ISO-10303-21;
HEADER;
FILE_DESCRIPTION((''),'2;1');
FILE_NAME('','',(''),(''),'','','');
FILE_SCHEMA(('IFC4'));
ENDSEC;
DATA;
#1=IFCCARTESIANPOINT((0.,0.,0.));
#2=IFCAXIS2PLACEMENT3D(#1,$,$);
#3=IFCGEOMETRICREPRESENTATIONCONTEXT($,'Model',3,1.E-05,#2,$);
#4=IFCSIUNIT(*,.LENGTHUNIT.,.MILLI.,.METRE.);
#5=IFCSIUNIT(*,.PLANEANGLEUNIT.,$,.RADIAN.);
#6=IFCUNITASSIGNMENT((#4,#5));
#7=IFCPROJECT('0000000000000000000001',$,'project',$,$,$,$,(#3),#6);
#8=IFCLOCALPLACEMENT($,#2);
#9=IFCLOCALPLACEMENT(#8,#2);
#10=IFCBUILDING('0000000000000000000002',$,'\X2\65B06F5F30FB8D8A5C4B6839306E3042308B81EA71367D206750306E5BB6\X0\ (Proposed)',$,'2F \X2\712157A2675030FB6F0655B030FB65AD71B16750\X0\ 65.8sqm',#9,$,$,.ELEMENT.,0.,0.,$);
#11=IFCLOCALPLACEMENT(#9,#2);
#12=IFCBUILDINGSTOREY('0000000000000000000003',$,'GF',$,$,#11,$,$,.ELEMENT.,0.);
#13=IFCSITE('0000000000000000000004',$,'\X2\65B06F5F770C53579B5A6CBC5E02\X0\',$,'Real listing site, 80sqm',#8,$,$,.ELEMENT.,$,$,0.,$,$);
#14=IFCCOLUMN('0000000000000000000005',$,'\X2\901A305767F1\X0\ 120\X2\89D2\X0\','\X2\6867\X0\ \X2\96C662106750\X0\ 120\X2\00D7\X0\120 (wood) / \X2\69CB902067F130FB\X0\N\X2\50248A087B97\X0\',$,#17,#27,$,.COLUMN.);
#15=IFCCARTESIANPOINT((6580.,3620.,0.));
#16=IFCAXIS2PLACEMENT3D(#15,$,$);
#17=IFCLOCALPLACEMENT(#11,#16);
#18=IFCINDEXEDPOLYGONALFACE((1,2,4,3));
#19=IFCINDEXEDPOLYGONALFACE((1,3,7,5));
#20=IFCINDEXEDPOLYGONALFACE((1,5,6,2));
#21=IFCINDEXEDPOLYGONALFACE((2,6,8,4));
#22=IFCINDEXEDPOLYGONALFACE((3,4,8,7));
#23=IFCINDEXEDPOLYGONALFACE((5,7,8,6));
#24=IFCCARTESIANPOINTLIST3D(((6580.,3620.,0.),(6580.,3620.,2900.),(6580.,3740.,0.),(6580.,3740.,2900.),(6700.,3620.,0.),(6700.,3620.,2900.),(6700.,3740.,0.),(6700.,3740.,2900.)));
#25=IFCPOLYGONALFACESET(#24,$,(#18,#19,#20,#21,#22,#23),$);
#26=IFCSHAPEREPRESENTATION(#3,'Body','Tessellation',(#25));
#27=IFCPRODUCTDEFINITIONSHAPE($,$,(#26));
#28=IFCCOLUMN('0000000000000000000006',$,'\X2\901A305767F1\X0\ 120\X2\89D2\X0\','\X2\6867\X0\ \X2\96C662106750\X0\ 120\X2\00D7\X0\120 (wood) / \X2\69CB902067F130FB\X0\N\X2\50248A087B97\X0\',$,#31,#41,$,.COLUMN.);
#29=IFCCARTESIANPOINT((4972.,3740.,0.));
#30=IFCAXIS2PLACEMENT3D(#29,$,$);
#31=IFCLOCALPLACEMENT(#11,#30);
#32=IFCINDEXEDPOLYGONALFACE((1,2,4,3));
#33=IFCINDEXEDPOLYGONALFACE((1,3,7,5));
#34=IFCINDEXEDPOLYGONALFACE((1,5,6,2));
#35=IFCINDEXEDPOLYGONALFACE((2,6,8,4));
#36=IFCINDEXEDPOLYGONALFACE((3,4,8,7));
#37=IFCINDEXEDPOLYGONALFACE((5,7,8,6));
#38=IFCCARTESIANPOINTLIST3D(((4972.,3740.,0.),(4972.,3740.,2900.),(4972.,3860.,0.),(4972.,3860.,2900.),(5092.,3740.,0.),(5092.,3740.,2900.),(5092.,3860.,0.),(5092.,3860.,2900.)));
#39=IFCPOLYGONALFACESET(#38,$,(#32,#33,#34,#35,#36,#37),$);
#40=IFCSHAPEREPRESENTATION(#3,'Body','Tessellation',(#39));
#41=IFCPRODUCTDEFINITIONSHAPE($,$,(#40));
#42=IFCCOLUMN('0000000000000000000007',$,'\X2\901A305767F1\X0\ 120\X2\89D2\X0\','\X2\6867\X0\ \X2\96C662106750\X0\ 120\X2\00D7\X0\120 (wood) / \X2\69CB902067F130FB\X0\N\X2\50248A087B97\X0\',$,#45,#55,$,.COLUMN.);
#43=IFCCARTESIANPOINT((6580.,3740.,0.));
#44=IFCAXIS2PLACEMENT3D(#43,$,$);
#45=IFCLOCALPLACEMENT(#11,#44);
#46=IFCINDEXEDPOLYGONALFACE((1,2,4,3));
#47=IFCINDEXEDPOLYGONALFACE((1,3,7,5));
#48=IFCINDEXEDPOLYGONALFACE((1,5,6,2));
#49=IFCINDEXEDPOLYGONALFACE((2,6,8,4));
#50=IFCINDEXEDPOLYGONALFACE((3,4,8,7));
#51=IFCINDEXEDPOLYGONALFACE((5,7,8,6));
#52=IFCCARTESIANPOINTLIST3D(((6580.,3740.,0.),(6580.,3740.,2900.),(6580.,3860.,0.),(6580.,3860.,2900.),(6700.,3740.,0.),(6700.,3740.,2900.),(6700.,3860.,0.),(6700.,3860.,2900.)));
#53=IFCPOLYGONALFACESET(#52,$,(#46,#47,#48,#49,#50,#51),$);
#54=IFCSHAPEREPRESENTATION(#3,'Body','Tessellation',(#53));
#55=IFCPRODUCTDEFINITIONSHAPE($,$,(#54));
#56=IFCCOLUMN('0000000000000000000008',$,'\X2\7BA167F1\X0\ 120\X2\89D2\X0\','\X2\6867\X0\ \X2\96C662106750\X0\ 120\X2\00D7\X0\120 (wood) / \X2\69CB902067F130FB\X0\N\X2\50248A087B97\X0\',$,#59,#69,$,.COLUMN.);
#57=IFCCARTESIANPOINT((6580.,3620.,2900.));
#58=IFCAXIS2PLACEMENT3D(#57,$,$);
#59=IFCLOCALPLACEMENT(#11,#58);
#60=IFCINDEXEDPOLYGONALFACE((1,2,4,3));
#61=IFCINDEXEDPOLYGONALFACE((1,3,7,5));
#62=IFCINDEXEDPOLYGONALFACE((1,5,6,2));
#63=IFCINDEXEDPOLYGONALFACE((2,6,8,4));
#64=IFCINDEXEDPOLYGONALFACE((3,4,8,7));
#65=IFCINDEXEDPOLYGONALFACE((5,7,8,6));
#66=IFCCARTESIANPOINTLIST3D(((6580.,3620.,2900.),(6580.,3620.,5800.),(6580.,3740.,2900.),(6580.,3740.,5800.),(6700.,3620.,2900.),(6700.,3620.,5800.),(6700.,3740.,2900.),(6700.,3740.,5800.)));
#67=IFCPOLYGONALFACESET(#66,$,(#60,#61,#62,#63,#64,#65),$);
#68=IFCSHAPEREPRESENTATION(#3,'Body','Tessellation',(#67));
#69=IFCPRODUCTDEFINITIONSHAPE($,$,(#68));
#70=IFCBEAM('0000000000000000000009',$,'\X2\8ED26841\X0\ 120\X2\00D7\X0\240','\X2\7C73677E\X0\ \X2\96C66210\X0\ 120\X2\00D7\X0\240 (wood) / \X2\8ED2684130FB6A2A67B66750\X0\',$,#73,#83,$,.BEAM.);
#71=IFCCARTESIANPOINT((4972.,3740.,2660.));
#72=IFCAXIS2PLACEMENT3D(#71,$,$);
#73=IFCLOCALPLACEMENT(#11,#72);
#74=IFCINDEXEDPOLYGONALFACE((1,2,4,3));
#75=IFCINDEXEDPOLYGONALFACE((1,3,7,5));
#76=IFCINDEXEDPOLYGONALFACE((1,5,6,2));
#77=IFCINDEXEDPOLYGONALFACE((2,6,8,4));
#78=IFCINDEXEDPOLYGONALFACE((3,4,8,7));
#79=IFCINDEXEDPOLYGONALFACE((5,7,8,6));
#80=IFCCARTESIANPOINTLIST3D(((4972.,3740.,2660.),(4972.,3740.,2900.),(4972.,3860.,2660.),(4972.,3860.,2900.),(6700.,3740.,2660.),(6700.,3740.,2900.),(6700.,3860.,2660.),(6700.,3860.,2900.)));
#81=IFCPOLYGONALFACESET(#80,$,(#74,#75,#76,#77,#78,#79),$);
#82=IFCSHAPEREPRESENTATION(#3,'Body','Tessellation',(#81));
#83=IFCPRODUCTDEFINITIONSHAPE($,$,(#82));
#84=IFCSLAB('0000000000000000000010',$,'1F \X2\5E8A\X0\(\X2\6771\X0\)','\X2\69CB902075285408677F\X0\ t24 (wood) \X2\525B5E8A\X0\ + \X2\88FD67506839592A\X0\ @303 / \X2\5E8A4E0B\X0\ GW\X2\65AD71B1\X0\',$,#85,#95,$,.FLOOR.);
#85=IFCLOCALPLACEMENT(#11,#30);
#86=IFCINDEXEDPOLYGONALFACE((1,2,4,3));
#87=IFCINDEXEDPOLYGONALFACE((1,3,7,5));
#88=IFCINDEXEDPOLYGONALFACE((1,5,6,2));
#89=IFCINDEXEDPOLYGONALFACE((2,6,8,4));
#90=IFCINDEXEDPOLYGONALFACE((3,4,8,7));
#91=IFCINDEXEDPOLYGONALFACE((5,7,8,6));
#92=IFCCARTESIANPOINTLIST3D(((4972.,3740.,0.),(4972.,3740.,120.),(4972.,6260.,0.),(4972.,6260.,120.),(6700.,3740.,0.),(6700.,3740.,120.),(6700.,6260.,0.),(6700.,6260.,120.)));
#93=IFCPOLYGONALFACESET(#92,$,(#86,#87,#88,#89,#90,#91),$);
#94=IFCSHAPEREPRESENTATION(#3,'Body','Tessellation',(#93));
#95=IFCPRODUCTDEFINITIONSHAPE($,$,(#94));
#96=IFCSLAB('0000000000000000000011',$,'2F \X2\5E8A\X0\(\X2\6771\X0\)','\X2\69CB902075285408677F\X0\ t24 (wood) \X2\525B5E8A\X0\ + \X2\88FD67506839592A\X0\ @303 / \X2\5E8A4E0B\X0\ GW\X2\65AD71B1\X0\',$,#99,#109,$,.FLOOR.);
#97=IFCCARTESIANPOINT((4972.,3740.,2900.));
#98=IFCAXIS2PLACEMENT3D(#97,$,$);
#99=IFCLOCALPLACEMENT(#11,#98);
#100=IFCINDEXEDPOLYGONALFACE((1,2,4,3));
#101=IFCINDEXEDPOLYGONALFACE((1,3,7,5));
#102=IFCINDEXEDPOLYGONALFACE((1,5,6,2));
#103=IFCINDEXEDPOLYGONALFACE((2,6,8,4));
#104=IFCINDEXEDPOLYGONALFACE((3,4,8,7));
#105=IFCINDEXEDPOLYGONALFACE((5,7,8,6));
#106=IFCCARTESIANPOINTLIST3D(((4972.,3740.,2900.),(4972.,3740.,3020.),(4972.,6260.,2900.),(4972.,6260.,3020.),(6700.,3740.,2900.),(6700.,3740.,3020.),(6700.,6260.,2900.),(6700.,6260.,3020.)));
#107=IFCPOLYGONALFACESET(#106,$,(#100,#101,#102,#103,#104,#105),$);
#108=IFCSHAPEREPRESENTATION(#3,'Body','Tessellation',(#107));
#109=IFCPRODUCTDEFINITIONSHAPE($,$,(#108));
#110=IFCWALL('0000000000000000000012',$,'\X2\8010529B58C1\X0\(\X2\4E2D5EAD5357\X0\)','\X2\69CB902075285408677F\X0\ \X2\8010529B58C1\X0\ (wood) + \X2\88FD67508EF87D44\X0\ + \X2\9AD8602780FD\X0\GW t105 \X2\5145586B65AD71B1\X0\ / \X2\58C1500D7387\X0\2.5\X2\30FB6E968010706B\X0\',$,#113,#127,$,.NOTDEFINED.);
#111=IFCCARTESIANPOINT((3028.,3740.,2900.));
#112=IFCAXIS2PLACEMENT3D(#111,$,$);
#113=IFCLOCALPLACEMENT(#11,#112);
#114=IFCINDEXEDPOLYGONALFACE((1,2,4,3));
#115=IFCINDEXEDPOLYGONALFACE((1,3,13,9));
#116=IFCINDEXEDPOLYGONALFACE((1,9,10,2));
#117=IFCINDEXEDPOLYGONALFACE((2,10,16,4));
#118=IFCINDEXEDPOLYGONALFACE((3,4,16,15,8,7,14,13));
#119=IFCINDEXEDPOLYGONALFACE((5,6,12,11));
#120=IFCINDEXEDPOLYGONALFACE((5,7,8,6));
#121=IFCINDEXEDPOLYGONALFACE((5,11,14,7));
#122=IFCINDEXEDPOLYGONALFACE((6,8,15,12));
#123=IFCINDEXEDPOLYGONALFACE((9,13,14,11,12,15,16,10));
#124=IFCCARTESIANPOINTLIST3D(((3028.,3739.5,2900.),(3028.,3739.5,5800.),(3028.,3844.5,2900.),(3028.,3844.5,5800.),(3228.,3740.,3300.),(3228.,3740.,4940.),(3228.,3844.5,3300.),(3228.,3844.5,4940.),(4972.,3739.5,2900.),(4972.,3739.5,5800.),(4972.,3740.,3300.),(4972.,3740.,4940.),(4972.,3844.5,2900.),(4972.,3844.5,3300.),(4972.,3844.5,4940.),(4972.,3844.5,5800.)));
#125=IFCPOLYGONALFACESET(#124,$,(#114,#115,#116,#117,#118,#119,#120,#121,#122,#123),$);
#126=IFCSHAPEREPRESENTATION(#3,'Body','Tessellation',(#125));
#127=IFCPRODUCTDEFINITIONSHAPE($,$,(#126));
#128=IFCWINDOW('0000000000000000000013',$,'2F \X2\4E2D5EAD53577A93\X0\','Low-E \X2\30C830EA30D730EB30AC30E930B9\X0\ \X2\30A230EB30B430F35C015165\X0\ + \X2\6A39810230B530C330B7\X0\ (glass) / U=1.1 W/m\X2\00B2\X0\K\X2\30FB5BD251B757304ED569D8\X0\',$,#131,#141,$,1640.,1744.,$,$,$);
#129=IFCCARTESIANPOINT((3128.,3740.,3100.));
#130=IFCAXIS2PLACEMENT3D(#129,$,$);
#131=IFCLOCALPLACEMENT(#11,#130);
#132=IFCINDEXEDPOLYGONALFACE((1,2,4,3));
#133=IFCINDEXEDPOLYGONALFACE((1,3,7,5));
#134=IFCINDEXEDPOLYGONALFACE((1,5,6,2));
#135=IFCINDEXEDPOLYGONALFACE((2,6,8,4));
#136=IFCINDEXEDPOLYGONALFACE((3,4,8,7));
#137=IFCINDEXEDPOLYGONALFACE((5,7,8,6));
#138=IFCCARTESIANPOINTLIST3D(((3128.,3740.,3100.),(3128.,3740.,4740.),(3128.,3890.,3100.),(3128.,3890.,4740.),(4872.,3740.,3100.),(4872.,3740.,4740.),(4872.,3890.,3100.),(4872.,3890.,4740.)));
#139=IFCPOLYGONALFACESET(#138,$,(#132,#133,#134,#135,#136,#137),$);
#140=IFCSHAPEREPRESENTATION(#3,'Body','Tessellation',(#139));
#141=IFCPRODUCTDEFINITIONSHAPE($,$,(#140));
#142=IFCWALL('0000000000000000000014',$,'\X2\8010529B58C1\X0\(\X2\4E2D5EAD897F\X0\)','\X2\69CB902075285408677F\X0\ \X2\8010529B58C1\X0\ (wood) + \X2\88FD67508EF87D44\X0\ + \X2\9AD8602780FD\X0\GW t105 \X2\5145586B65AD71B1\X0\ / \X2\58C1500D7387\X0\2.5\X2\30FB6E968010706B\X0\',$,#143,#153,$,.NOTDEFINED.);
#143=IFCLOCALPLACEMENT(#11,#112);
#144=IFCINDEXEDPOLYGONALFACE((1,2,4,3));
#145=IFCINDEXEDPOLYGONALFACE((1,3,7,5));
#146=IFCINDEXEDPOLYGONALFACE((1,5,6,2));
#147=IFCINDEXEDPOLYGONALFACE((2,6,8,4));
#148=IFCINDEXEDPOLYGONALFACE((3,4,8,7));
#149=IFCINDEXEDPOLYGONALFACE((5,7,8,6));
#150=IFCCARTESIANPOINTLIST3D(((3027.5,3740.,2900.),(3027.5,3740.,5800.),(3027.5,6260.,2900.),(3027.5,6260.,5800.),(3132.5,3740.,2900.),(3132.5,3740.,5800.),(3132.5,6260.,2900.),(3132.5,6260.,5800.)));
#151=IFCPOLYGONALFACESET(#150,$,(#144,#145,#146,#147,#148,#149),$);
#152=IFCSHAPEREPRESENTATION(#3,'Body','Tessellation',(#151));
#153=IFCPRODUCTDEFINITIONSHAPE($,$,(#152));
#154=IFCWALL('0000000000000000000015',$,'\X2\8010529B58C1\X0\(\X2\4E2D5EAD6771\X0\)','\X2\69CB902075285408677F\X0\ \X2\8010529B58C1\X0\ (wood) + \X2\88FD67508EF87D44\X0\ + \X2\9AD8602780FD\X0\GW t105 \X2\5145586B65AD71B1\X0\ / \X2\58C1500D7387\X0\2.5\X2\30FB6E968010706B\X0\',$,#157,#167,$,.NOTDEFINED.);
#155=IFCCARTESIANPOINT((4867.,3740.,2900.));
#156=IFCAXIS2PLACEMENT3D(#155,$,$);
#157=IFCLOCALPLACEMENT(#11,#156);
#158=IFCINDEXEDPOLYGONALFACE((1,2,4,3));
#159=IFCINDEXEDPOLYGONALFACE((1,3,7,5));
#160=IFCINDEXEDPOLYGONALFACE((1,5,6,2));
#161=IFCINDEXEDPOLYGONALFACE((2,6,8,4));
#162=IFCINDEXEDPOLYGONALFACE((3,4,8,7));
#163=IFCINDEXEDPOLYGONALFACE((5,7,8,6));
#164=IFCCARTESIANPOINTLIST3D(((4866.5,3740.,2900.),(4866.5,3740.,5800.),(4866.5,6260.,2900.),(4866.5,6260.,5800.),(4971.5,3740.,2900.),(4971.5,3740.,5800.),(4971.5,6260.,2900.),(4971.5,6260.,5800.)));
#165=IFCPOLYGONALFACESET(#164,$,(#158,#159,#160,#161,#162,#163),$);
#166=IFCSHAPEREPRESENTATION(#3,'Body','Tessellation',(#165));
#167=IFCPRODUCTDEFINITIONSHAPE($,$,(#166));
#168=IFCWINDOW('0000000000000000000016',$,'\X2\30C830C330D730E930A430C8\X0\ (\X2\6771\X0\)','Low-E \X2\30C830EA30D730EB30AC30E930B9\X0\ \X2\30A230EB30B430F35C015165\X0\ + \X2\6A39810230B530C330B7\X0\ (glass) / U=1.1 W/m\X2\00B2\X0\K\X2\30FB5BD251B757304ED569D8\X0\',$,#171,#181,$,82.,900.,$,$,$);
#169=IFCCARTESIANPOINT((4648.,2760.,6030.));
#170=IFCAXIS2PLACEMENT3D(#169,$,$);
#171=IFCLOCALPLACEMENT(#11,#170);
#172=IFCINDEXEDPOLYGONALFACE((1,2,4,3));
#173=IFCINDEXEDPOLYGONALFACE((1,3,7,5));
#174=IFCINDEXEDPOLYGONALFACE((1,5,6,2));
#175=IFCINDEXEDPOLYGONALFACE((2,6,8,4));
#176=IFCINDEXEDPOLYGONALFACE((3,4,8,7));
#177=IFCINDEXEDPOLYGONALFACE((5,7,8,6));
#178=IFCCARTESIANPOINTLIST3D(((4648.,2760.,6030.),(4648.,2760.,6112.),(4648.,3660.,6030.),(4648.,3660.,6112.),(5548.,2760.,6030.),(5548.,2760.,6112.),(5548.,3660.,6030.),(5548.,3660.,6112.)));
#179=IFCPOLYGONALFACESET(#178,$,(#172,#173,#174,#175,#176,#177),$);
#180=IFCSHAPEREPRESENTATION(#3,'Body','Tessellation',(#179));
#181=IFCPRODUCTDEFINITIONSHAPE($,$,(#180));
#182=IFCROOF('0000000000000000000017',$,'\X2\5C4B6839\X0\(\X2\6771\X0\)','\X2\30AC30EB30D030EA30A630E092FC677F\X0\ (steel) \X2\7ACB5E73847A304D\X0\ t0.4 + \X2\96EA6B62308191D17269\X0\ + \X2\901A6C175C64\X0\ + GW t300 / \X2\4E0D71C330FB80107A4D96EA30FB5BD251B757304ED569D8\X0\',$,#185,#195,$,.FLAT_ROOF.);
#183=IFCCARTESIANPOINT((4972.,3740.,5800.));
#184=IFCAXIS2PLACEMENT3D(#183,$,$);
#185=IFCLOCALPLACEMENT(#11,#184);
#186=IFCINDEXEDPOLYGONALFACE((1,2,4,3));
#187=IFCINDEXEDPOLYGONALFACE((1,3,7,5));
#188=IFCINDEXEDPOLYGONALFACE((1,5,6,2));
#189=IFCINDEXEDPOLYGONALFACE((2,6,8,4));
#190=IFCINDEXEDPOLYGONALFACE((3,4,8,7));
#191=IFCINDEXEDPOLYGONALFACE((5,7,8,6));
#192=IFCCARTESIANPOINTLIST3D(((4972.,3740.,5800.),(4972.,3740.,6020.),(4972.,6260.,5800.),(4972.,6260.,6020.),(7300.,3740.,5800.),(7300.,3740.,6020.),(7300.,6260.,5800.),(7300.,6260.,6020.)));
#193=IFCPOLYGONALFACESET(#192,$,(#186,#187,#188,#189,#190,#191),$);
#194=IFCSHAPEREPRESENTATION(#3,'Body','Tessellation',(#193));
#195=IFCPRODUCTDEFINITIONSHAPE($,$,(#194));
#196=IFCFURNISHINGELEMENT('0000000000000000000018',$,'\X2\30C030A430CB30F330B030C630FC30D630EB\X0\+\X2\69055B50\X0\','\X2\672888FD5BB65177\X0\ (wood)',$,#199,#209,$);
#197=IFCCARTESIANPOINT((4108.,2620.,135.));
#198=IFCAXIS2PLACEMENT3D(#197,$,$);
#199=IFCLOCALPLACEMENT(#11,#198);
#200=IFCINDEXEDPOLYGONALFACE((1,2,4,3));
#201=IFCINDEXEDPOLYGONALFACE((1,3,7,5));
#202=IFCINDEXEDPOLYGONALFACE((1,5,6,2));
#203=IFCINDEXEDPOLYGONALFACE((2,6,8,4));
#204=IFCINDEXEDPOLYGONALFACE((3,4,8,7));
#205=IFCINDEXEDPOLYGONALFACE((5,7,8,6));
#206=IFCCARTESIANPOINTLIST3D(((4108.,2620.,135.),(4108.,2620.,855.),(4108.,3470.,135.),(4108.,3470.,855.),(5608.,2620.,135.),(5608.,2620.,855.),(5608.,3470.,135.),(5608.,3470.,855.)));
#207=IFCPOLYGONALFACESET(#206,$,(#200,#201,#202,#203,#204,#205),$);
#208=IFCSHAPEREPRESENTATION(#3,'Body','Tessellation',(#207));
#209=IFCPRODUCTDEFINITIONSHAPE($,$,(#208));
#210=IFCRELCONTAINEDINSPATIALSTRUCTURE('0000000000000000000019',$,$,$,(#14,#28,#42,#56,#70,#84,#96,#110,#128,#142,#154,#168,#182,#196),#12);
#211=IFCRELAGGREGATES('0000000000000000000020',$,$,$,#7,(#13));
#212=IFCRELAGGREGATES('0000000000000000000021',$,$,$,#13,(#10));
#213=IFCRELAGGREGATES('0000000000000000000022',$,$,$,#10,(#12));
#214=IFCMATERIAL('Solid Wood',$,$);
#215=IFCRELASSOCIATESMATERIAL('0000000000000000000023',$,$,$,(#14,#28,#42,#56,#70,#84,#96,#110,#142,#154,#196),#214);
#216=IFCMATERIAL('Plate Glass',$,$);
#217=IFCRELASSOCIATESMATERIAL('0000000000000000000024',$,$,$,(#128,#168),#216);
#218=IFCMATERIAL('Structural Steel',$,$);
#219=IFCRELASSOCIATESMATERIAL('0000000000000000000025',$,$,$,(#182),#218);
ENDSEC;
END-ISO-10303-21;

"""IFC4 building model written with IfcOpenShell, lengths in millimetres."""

from ifc_helpers import new_model, si_unit, frame, frame_2d, origin, place, context, project, spatial, rectangle, extrude, material, element, fill, save


model = new_model("IFC4")

# Units and contexts
model_context = context("Model", 3, precision=1e-05, world=origin())
ifc_project = project(units=[si_unit("LENGTHUNIT", "METRE", prefix="MILLI"), si_unit("PLANEANGLEUNIT", "RADIAN")], contexts=[model_context])

# Site, building, storey
site_placement = place(None, origin())
site = spatial("IfcSite", under=ifc_project, at=site_placement, Name="新潟県南魚沼市", ObjectType="Real listing site, 80sqm", CompositionType="ELEMENT", RefElevation=0.0)
building_placement = place(site_placement, origin())
building = spatial("IfcBuilding", under=site, at=building_placement, Name="新潟・越屋根のある自然素材の家 (Proposed)", ObjectType="2F 無垢材・漆喰・断熱材 65.8sqm", CompositionType="ELEMENT", ElevationOfRefHeight=0.0, ElevationOfTerrain=0.0)
storey_placement = place(building_placement, origin())
storey = spatial("IfcBuildingStorey", under=building, at=storey_placement, Name="GF", CompositionType="ELEMENT", Elevation=0.0)

# Columns
ifc_material_1 = material(Name="Solid Wood")
column_1_placement = place(storey_placement, frame((6580.0, 3620.0, 0.0)))
element("IfcColumn", 1, at=column_1_placement, inside=storey, material=ifc_material_1, Name="通し柱 120角", Description="桧 集成材 120×120 (wood) / 構造柱・N値計算", PredefinedType="COLUMN", context=model_context, shape_type="SweptSolid", body=[
    extrude(rectangle(XDim=120.0, YDim=120.0, at=frame_2d((60.0, 60.0))), frame((6580.0, 3620.0, 0.0)), (0.0, 0.0, 1.0), 2900.0),
])
column_2_placement = place(storey_placement, frame((4972.0, 3740.0, 0.0)))
element("IfcColumn", 2, at=column_2_placement, inside=storey, material=ifc_material_1, Name="通し柱 120角", Description="桧 集成材 120×120 (wood) / 構造柱・N値計算", PredefinedType="COLUMN", context=model_context, shape_type="SweptSolid", body=[
    extrude(rectangle(XDim=120.0, YDim=120.0, at=frame_2d((60.0, 60.0))), frame((4972.0, 3740.0, 0.0)), (0.0, 0.0, 1.0), 2900.0),
])
column_3_placement = place(storey_placement, frame((6580.0, 3740.0, 0.0)))
element("IfcColumn", 3, at=column_3_placement, inside=storey, material=ifc_material_1, Name="通し柱 120角", Description="桧 集成材 120×120 (wood) / 構造柱・N値計算", PredefinedType="COLUMN", context=model_context, shape_type="SweptSolid", body=[
    extrude(rectangle(XDim=120.0, YDim=120.0, at=frame_2d((60.0, 60.0))), frame((6580.0, 3740.0, 0.0)), (0.0, 0.0, 1.0), 2900.0),
])
column_4_placement = place(storey_placement, frame((6580.0, 3620.0, 2900.0)))
element("IfcColumn", 4, at=column_4_placement, inside=storey, material=ifc_material_1, Name="管柱 120角", Description="桧 集成材 120×120 (wood) / 構造柱・N値計算", PredefinedType="COLUMN", context=model_context, shape_type="SweptSolid", body=[
    extrude(rectangle(XDim=120.0, YDim=120.0, at=frame_2d((60.0, 60.0))), frame((6580.0, 3620.0, 2900.0)), (0.0, 0.0, 1.0), 2900.0),
])

# Beam
beam_1_placement = place(storey_placement, frame((4972.0, 3740.0, 2660.0)))
element("IfcBeam", 5, at=beam_1_placement, inside=storey, material=ifc_material_1, Name="軒桁 120×240", Description="米松 集成 120×240 (wood) / 軒桁・横架材", PredefinedType="BEAM", context=model_context, shape_type="SweptSolid", body=[
    extrude(rectangle(XDim=1728.0, YDim=120.0, at=frame_2d((864.0, 60.0))), frame((4972.0, 3740.0, 2660.0)), (0.0, 0.0, 1.0), 240.0),
])

# Slabs
slab_1_placement = place(storey_placement, frame((4972.0, 3740.0, 0.0)))
element("IfcSlab", 6, at=slab_1_placement, inside=storey, material=ifc_material_1, Name="1F 床(東)", Description="構造用合板 t24 (wood) 剛床 + 製材根太 @303 / 床下 GW断熱", PredefinedType="FLOOR", context=model_context, shape_type="SweptSolid", body=[
    extrude(rectangle(XDim=1728.0, YDim=2520.0, at=frame_2d((864.0, 1260.0))), frame((4972.0, 3740.0, 0.0)), (0.0, 0.0, 1.0), 120.0),
])
slab_2_placement = place(storey_placement, frame((4972.0, 3740.0, 2900.0)))
element("IfcSlab", 7, at=slab_2_placement, inside=storey, material=ifc_material_1, Name="2F 床(東)", Description="構造用合板 t24 (wood) 剛床 + 製材根太 @303 / 床下 GW断熱", PredefinedType="FLOOR", context=model_context, shape_type="SweptSolid", body=[
    extrude(rectangle(XDim=1728.0, YDim=2520.0, at=frame_2d((864.0, 1260.0))), frame((4972.0, 3740.0, 2900.0)), (0.0, 0.0, 1.0), 120.0),
])

# Wall, opening, window
wall_1_placement = place(storey_placement, frame((3028.0, 3740.0, 2900.0)))
wall_1 = element("IfcWall", 8, at=wall_1_placement, inside=storey, material=ifc_material_1, Name="耐力壁(中庭南)", Description="構造用合板 耐力壁 (wood) + 製材軸組 + 高性能GW t105 充填断熱 / 壁倍率2.5・準耐火", PredefinedType="NOTDEFINED", context=model_context, shape_type="SweptSolid", body=[
    extrude(rectangle(XDim=1944.0, YDim=105.0, at=frame_2d((972.0, 52.0))), frame((3028.0, 3740.0, 2900.0)), (0.0, 0.0, 1.0), 2900.0),
])
opening_placement = place(storey_placement, frame((3128.0, 3740.0, 3100.0)))
opening = element("IfcOpeningElement", 9, at=opening_placement, cuts=wall_1, PredefinedType="NOTDEFINED", context=model_context, shape_type="SweptSolid", body=[
    extrude(rectangle(XDim=1744.0, YDim=150.0, at=frame_2d((872.0, 75.0))), frame((3128.0, 3740.0, 3100.0)), (0.0, 0.0, 1.0), 1640.0),
])
ifc_material_2 = material(Name="Plate Glass")
window_1_placement = place(storey_placement, frame((3128.0, 3740.0, 3100.0)))
window_1 = element("IfcWindow", 10, at=window_1_placement, inside=storey, material=ifc_material_2, Name="2F 中庭南窓", Description="Low-E トリプルガラス アルゴン封入 + 樹脂サッシ (glass) / U=1.1 W/m²K・寒冷地仕様", OverallHeight=1640.0, OverallWidth=1744.0, context=model_context, shape_type="SweptSolid", body=[
    extrude(rectangle(XDim=1744.0, YDim=150.0, at=frame_2d((872.0, 75.0))), frame((3128.0, 3740.0, 3100.0)), (0.0, 0.0, 1.0), 1640.0),
])
fill(opening, window_1)

# Walls
wall_2_placement = place(storey_placement, frame((3028.0, 3740.0, 2900.0)))
element("IfcWall", 11, at=wall_2_placement, inside=storey, material=ifc_material_1, Name="耐力壁(中庭西)", Description="構造用合板 耐力壁 (wood) + 製材軸組 + 高性能GW t105 充填断熱 / 壁倍率2.5・準耐火", PredefinedType="NOTDEFINED", context=model_context, shape_type="SweptSolid", body=[
    extrude(rectangle(XDim=105.0, YDim=2520.0, at=frame_2d((52.0, 1260.0))), frame((3028.0, 3740.0, 2900.0)), (0.0, 0.0, 1.0), 2900.0),
])
wall_3_placement = place(storey_placement, frame((4867.0, 3740.0, 2900.0)))
element("IfcWall", 12, at=wall_3_placement, inside=storey, material=ifc_material_1, Name="耐力壁(中庭東)", Description="構造用合板 耐力壁 (wood) + 製材軸組 + 高性能GW t105 充填断熱 / 壁倍率2.5・準耐火", PredefinedType="NOTDEFINED", context=model_context, shape_type="SweptSolid", body=[
    extrude(rectangle(XDim=105.0, YDim=2520.0, at=frame_2d((52.0, 1260.0))), frame((4867.0, 3740.0, 2900.0)), (0.0, 0.0, 1.0), 2900.0),
])

# Window
window_2_placement = place(storey_placement, frame((4648.0, 2760.0, 6030.0)))
element("IfcWindow", 13, at=window_2_placement, inside=storey, material=ifc_material_2, Name="トップライト (東)", Description="Low-E トリプルガラス アルゴン封入 + 樹脂サッシ (glass) / U=1.1 W/m²K・寒冷地仕様", OverallHeight=82.0, OverallWidth=900.0, context=model_context, shape_type="SweptSolid", body=[
    extrude(rectangle(XDim=900.0, YDim=900.0, at=frame_2d((450.0, 450.0))), frame((4648.0, 2760.0, 6030.0)), (0.0, 0.0, 1.0), 82.0),
])

# Roof
ifc_material_3 = material(Name="Structural Steel")
for number, where, name in (
    (14, (4972.0, 3740.0, 5800.0), "屋根(東)"),
):
    element("IfcRoof", number, at=place(storey_placement, frame(where)), inside=storey, material=ifc_material_3, Name=name, Description="ガルバリウム鋼板 (steel) 立平葺き t0.4 + 雪止め金物 + 通気層 + GW t300 / 不燃・耐積雪・寒冷地仕様", PredefinedType="FLAT_ROOF", context=model_context, shape_type="SweptSolid", body=[
        extrude(rectangle(XDim=2328.0, YDim=2520.0, at=frame_2d((1164.0, 1260.0))), frame((4972.0, 3740.0, 5800.0)), (0.0, 0.0, 1.0), 220.0),
    ])

# Furnishing element
furnishing_1_placement = place(storey_placement, frame((4108.0, 2620.0, 135.0)))
element("IfcFurnishingElement", 15, at=furnishing_1_placement, inside=storey, material=ifc_material_1, Name="ダイニングテーブル+椅子", Description="木製家具 (wood)", context=model_context, shape_type="SweptSolid", body=[
    extrude(rectangle(XDim=1500.0, YDim=850.0, at=frame_2d((750.0, 425.0))), frame((4108.0, 2620.0, 135.0)), (0.0, 0.0, 1.0), 720.0),
])

save(model, "model.ifc")
